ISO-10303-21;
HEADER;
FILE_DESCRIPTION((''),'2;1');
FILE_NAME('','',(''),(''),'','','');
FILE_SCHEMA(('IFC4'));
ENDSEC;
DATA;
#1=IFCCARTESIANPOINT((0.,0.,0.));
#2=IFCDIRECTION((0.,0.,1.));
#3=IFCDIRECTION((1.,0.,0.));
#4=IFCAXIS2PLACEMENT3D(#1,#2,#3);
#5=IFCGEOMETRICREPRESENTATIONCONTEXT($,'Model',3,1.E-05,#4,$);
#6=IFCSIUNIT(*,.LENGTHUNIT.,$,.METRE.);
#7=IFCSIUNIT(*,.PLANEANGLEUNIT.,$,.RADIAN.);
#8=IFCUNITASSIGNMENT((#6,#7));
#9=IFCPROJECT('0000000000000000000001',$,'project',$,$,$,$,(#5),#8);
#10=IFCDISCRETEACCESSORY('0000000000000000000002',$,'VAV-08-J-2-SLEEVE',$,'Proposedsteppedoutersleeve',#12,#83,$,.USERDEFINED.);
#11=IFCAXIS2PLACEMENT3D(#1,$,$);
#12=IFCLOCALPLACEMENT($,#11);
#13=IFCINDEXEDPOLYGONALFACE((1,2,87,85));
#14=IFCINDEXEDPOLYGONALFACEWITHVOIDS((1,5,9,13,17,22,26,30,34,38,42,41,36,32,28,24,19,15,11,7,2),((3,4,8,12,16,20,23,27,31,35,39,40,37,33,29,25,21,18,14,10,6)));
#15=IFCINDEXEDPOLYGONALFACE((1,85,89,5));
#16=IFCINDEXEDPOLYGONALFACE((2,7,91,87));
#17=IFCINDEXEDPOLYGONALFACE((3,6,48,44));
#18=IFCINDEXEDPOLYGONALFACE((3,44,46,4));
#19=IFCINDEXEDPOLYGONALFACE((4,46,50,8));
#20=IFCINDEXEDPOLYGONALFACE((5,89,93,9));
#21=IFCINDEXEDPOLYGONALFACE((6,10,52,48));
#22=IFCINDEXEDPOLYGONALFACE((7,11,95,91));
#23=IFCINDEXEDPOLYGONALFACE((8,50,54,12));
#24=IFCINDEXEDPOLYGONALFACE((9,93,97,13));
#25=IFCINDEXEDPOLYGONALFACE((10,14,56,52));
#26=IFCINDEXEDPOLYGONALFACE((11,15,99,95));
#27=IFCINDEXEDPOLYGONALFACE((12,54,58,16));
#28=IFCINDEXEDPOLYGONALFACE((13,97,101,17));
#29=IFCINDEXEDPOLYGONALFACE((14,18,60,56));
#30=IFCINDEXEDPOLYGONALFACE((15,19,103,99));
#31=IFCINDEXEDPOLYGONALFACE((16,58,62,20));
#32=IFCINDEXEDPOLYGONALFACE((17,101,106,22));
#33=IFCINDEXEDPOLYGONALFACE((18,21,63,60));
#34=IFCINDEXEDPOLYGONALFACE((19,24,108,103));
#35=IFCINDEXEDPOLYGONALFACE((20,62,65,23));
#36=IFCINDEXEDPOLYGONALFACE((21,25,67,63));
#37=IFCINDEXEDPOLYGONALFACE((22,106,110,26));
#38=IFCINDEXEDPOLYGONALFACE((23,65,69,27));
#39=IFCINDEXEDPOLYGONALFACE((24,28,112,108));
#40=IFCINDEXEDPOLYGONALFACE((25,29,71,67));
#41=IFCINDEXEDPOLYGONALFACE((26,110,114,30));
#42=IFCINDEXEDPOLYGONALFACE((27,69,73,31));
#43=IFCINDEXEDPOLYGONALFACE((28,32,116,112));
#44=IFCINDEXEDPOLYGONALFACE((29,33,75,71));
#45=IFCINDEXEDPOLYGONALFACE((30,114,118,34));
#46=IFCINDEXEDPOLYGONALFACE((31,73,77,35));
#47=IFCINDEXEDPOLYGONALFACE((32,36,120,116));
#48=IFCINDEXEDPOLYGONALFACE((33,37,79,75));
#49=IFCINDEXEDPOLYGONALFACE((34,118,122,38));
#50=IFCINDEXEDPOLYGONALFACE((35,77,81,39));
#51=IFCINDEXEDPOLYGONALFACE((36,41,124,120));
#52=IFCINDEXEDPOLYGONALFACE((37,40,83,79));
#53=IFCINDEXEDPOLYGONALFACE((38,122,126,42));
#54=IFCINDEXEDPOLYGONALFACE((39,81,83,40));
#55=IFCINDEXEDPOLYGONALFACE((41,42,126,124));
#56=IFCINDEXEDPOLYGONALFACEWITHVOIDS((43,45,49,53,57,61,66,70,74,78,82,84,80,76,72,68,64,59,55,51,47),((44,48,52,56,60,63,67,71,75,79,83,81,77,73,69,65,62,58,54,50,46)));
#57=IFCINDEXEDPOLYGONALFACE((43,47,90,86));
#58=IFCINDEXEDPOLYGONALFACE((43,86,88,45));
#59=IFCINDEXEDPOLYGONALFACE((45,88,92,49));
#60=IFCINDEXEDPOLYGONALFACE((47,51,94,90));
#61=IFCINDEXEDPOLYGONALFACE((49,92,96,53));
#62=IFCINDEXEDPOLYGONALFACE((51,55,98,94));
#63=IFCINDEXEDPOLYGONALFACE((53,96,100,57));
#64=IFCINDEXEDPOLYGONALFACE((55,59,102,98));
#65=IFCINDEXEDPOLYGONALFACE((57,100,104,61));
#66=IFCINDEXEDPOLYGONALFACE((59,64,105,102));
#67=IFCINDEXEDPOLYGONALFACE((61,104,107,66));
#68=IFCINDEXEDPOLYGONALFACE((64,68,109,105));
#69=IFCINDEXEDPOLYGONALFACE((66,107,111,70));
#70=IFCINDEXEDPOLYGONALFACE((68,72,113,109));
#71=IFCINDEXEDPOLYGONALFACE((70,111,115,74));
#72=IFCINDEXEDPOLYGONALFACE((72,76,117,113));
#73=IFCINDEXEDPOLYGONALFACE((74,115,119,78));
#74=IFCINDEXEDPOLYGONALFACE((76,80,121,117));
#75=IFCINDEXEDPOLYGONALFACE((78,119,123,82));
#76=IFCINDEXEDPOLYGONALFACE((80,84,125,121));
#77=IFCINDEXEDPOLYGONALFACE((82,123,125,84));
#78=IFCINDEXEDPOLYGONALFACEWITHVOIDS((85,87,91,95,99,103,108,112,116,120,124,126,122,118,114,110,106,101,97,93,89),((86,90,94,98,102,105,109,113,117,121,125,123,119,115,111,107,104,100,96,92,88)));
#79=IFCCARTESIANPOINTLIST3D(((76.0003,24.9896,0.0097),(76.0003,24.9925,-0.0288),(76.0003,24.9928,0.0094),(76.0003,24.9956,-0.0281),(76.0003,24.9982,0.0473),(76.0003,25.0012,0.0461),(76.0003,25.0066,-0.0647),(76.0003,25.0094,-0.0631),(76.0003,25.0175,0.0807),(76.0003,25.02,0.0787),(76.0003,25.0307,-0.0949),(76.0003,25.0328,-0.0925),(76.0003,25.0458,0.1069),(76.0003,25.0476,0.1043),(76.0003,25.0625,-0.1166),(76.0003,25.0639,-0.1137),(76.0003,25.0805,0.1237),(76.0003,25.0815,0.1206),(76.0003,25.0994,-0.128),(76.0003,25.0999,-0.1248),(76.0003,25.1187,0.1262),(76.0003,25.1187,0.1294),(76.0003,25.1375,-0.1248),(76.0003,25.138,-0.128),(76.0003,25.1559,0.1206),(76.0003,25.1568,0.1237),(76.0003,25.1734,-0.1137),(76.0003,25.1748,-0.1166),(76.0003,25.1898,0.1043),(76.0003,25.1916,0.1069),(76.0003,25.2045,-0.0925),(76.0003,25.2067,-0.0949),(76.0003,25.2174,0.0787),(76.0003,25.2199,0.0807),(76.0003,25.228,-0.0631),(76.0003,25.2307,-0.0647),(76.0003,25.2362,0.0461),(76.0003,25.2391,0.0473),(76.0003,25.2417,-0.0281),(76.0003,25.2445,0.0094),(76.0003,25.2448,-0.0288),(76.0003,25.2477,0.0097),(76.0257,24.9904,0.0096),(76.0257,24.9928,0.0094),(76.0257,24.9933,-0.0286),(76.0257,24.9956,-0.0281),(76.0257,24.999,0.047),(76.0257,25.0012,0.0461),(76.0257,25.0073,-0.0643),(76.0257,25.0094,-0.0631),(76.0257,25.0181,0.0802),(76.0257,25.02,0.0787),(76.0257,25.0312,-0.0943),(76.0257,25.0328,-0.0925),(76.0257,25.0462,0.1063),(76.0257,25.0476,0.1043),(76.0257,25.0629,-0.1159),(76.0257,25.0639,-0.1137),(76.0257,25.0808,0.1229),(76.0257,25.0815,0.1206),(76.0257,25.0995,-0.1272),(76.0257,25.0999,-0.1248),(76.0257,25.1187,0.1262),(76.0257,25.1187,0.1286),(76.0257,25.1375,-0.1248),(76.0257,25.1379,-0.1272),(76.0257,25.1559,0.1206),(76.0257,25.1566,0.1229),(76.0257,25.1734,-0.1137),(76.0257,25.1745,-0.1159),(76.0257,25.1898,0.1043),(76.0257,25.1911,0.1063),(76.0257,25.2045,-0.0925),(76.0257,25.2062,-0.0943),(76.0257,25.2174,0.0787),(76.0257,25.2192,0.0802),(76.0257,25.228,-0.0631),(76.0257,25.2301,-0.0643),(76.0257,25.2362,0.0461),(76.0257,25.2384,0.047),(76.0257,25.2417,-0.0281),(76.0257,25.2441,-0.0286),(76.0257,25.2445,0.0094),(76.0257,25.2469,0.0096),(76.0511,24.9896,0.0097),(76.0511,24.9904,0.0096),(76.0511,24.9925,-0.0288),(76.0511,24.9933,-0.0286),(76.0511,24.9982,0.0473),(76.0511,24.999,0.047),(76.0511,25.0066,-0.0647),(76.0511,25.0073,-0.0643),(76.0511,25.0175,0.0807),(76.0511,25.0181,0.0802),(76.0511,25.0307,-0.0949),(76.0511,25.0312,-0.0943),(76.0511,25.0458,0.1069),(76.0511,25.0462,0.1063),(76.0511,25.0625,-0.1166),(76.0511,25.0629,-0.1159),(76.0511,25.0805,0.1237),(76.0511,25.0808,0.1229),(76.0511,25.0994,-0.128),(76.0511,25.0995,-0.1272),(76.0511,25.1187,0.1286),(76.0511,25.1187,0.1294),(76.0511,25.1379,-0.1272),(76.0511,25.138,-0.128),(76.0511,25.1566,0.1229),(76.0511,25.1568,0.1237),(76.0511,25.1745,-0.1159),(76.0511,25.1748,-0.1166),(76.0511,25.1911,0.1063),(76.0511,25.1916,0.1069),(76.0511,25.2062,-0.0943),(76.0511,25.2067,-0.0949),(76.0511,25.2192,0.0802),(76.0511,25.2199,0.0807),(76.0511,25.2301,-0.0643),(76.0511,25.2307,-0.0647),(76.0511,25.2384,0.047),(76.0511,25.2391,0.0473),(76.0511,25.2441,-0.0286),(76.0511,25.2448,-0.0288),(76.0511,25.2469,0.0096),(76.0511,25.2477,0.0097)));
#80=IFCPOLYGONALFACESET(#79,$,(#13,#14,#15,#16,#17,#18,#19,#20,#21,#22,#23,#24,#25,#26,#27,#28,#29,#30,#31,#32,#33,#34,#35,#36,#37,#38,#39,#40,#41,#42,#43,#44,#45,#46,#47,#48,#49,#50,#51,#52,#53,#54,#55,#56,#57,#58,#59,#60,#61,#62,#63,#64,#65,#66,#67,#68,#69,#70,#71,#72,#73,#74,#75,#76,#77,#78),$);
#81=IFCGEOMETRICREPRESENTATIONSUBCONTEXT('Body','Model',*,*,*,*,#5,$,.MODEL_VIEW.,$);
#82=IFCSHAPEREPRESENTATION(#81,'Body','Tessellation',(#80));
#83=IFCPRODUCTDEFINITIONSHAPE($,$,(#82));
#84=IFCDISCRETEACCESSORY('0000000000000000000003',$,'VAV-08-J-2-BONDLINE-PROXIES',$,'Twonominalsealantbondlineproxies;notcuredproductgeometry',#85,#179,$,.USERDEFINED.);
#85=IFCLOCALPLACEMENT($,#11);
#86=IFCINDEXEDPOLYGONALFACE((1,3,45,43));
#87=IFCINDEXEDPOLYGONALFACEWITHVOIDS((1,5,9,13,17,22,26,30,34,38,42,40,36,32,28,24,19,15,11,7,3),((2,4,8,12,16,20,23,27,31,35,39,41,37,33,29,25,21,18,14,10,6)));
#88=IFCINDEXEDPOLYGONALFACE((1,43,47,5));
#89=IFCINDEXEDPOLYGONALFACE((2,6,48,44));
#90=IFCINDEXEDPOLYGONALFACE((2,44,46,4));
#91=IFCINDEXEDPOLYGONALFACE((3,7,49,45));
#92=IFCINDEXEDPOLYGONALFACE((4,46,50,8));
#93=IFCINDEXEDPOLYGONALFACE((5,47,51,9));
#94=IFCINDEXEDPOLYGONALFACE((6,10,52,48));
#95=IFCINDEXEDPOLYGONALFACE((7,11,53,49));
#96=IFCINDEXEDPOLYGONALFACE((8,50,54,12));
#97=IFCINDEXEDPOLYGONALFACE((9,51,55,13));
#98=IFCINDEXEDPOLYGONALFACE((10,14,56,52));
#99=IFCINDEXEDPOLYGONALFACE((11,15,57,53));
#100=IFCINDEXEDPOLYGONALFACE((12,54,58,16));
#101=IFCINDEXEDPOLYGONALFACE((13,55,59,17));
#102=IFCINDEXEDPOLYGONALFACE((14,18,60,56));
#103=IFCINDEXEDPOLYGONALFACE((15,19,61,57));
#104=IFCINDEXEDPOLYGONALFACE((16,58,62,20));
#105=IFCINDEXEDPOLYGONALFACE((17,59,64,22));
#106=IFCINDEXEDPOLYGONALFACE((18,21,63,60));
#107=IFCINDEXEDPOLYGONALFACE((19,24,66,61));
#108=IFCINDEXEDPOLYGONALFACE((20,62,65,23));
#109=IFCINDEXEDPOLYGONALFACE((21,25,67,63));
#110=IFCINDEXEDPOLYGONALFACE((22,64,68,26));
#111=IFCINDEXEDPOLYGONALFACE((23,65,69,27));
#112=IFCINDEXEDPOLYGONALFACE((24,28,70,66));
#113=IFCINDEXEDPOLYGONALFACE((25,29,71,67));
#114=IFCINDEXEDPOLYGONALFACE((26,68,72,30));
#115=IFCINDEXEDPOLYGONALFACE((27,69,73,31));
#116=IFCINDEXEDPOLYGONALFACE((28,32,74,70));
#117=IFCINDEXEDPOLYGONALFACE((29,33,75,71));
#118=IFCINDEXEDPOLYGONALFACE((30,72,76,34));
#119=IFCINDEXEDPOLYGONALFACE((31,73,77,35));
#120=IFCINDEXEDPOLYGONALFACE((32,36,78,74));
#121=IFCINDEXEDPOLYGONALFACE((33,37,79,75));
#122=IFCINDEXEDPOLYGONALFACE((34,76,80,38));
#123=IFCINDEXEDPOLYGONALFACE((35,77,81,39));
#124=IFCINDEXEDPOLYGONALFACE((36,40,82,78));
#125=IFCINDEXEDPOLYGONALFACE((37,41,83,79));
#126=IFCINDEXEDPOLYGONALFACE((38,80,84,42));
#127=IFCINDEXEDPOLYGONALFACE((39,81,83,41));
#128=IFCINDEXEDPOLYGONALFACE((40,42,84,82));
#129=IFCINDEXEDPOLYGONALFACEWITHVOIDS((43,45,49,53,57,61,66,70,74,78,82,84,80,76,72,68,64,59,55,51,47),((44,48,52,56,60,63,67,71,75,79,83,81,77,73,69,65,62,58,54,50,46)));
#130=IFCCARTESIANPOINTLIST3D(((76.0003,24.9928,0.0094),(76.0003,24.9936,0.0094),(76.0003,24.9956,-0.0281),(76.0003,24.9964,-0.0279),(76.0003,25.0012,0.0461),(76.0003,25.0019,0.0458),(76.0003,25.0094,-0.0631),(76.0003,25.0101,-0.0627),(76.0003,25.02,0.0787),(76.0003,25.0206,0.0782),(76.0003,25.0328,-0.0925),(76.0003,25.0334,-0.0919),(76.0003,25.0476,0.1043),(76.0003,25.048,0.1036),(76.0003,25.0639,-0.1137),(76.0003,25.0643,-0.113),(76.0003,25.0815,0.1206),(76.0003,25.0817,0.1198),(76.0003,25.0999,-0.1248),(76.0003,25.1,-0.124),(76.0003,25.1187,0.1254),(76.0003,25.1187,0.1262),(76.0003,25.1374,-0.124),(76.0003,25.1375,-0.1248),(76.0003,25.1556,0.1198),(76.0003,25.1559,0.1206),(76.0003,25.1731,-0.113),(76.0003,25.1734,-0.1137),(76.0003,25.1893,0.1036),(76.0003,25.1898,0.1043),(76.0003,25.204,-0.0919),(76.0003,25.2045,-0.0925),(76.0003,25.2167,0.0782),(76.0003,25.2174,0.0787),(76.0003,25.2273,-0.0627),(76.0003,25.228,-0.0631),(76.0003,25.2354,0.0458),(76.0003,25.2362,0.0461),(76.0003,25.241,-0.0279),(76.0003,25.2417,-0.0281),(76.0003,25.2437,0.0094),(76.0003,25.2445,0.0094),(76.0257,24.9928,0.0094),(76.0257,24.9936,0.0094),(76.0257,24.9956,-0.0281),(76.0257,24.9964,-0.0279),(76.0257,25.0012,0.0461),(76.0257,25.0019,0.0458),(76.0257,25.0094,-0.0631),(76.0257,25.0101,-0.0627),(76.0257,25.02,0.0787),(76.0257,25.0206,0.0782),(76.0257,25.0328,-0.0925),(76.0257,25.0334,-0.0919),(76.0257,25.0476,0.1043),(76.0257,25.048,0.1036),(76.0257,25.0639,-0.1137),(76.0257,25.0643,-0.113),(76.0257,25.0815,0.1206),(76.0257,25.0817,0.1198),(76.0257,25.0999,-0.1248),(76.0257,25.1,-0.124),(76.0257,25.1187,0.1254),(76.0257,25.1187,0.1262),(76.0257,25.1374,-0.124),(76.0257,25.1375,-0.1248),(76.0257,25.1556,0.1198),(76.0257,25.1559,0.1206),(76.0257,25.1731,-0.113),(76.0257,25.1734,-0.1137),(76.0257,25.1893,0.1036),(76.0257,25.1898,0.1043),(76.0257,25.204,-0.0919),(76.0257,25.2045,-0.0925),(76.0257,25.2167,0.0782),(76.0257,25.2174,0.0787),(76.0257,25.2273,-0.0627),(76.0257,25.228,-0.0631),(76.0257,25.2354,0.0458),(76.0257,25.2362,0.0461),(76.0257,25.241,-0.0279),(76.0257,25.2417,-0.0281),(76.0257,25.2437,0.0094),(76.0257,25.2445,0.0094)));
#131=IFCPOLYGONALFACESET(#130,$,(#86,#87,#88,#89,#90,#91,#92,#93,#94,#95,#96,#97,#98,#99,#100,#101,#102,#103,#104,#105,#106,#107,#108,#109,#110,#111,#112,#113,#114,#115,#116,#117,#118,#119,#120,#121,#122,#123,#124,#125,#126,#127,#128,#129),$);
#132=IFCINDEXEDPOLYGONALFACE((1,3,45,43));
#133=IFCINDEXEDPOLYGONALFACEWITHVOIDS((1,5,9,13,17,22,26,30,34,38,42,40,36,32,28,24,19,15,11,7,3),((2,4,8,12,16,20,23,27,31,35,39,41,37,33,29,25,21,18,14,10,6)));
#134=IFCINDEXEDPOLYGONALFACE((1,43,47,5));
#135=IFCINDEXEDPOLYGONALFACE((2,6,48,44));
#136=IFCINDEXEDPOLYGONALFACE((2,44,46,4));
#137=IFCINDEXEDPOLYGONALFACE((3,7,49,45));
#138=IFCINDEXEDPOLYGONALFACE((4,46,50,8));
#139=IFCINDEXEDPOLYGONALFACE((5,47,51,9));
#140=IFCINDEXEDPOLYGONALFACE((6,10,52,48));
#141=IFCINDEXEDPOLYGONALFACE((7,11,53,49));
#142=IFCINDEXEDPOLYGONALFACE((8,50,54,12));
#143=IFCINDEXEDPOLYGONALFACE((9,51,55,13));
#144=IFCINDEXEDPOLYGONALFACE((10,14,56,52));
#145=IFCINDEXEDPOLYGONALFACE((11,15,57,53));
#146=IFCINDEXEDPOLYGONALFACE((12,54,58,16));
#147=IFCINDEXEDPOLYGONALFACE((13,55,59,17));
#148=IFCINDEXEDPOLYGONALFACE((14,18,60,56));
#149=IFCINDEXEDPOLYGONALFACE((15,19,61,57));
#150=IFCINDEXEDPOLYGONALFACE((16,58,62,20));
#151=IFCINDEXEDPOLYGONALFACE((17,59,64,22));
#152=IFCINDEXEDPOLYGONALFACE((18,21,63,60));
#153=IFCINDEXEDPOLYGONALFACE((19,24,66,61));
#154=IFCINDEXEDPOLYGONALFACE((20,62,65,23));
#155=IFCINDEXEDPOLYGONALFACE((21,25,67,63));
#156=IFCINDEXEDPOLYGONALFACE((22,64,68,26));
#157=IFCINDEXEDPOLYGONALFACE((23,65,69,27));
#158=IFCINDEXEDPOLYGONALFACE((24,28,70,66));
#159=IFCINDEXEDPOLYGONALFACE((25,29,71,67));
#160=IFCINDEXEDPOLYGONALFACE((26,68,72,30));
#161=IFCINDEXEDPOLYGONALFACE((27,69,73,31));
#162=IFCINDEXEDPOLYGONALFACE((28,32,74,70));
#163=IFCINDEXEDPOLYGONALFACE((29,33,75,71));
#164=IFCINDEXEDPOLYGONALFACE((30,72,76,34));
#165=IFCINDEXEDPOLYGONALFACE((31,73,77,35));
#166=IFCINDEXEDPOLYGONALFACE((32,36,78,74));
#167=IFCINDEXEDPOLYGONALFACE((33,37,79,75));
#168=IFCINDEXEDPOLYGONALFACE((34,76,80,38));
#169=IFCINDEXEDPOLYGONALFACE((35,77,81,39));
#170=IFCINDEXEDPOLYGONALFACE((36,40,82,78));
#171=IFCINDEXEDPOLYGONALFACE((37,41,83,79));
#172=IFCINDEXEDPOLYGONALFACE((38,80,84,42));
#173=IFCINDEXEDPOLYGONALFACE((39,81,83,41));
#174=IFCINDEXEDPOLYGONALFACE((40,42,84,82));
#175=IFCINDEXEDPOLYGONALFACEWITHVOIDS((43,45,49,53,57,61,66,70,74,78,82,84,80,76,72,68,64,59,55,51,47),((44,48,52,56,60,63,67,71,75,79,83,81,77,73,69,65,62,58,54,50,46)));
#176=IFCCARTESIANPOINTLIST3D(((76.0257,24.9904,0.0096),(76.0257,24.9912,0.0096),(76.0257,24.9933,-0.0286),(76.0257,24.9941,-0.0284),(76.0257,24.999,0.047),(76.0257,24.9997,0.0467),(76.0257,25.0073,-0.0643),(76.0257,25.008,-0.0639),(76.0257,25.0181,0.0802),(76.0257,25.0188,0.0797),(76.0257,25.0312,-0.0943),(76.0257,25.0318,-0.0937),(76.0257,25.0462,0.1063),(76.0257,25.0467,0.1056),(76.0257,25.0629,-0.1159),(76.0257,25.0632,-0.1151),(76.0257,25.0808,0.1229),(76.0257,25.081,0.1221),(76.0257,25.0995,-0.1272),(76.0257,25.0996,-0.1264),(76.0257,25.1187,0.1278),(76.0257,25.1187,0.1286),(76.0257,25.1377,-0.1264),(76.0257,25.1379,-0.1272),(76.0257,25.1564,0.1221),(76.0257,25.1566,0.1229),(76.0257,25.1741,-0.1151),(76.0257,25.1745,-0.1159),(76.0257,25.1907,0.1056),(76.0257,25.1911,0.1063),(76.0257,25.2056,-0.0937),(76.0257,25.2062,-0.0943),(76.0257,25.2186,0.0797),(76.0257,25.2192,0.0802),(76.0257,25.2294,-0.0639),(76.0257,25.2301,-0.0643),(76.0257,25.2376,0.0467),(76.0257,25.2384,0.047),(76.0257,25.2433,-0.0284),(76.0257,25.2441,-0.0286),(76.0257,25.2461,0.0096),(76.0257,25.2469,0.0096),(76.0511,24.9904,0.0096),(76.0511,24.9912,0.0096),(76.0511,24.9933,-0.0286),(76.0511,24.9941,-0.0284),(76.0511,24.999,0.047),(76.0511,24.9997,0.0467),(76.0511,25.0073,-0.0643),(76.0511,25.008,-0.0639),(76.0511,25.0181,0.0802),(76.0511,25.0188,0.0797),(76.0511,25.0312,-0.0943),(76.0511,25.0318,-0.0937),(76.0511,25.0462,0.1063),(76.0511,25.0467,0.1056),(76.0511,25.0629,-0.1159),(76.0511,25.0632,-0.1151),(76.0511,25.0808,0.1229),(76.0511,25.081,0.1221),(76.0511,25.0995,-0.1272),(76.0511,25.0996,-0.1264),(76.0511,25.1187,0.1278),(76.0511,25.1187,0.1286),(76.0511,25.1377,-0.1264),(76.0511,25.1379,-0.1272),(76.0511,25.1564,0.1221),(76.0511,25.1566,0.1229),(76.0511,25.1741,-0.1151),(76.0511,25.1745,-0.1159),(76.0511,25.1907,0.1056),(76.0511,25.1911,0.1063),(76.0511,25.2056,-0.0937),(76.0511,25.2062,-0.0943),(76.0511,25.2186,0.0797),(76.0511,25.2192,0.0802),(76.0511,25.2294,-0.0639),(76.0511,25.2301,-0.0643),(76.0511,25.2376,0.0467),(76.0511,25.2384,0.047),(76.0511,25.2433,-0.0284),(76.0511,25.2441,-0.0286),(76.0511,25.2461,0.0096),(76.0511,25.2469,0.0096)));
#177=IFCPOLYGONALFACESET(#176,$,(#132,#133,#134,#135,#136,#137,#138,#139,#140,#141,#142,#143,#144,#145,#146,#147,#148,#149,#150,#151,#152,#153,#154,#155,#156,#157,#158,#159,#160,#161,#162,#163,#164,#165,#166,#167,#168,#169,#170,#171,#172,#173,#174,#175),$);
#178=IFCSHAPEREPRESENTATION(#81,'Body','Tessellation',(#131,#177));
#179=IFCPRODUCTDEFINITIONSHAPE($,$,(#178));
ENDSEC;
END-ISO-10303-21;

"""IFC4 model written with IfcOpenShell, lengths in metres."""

from ifc_helpers import new_model, entity, si_unit, frame, origin_with_axes, place, context, subcontext, project, element, save


model = new_model("IFC4")

# Units and contexts
model_context = context("Model", 3, precision=1e-05, world=origin_with_axes())
body_context = subcontext(model_context, "Body", "Model", "MODEL_VIEW")
ifc_project = project(units=[si_unit("LENGTHUNIT", "METRE"), si_unit("PLANEANGLEUNIT", "RADIAN")], contexts=[model_context])

# Discrete accessories
discrete_accessory_1_placement = place(None, frame((76.0257, 25.1187, 0.0), z_axis=(0.0, 1.0, 0.0), x_axis=(0.0, 0.0, 1.0)))
element("IfcDiscreteAccessory", 1, at=discrete_accessory_1_placement, Name="VAV-08-J-2-SLEEVE", ObjectType="Proposedsteppedoutersleeve", PredefinedType="USERDEFINED", context=body_context, shape_type="SweptSolid", body=[
    entity("IfcRevolvedAreaSolid", entity("IfcArbitraryClosedProfileDef", "AREA", None, entity("IfcPolyline", [entity("IfcCartesianPoint", [0.1262, -0.0254]), entity("IfcCartesianPoint", [0.1294, -0.0254]), entity("IfcCartesianPoint", [0.1294, 0.0254]), entity("IfcCartesianPoint", [0.1286, 0.0254]), entity("IfcCartesianPoint", [0.1286, 0.0]), entity("IfcCartesianPoint", [0.1262, 0.0]), entity("IfcCartesianPoint", [0.1262, -0.0254])])), entity("IfcAxis2Placement3D", entity("IfcCartesianPoint", [0.0, 0.0, 0.0])), entity("IfcAxis1Placement", entity("IfcCartesianPoint", [0.0, 0.0, 0.0]), entity("IfcDirection", [0.0, 1.0, 0.0])), 6.283185),
])
discrete_accessory_2_placement = place(None, frame((76.0257, 25.1187, 0.0), z_axis=(0.0, 1.0, 0.0), x_axis=(0.0, 0.0, 1.0)))
element("IfcDiscreteAccessory", 2, at=discrete_accessory_2_placement, Name="VAV-08-J-2-BONDLINE-PROXIES", ObjectType="Twonominalsealantbondlineproxies;notcuredproductgeometry", PredefinedType="USERDEFINED", context=body_context, shape_type="SweptSolid", body=[
    entity("IfcRevolvedAreaSolid", entity("IfcArbitraryClosedProfileDef", "AREA", None, entity("IfcPolyline", [entity("IfcCartesianPoint", [0.1254, -0.0254]), entity("IfcCartesianPoint", [0.1262, -0.0254]), entity("IfcCartesianPoint", [0.1262, 0.0]), entity("IfcCartesianPoint", [0.1254, 0.0]), entity("IfcCartesianPoint", [0.1254, -0.0254])])), entity("IfcAxis2Placement3D", entity("IfcCartesianPoint", [0.0, 0.0, 0.0])), entity("IfcAxis1Placement", entity("IfcCartesianPoint", [0.0, 0.0, 0.0]), entity("IfcDirection", [0.0, 1.0, 0.0])), 6.283185),
    entity("IfcRevolvedAreaSolid", entity("IfcArbitraryClosedProfileDef", "AREA", None, entity("IfcPolyline", [entity("IfcCartesianPoint", [0.1278, 0.0]), entity("IfcCartesianPoint", [0.1286, 0.0]), entity("IfcCartesianPoint", [0.1286, 0.0254]), entity("IfcCartesianPoint", [0.1278, 0.0254]), entity("IfcCartesianPoint", [0.1278, 0.0])])), entity("IfcAxis2Placement3D", entity("IfcCartesianPoint", [0.0, 0.0, 0.0])), entity("IfcAxis1Placement", entity("IfcCartesianPoint", [0.0, 0.0, 0.0]), entity("IfcDirection", [0.0, 1.0, 0.0])), 6.283185),
])

save(model, "model.ifc")
